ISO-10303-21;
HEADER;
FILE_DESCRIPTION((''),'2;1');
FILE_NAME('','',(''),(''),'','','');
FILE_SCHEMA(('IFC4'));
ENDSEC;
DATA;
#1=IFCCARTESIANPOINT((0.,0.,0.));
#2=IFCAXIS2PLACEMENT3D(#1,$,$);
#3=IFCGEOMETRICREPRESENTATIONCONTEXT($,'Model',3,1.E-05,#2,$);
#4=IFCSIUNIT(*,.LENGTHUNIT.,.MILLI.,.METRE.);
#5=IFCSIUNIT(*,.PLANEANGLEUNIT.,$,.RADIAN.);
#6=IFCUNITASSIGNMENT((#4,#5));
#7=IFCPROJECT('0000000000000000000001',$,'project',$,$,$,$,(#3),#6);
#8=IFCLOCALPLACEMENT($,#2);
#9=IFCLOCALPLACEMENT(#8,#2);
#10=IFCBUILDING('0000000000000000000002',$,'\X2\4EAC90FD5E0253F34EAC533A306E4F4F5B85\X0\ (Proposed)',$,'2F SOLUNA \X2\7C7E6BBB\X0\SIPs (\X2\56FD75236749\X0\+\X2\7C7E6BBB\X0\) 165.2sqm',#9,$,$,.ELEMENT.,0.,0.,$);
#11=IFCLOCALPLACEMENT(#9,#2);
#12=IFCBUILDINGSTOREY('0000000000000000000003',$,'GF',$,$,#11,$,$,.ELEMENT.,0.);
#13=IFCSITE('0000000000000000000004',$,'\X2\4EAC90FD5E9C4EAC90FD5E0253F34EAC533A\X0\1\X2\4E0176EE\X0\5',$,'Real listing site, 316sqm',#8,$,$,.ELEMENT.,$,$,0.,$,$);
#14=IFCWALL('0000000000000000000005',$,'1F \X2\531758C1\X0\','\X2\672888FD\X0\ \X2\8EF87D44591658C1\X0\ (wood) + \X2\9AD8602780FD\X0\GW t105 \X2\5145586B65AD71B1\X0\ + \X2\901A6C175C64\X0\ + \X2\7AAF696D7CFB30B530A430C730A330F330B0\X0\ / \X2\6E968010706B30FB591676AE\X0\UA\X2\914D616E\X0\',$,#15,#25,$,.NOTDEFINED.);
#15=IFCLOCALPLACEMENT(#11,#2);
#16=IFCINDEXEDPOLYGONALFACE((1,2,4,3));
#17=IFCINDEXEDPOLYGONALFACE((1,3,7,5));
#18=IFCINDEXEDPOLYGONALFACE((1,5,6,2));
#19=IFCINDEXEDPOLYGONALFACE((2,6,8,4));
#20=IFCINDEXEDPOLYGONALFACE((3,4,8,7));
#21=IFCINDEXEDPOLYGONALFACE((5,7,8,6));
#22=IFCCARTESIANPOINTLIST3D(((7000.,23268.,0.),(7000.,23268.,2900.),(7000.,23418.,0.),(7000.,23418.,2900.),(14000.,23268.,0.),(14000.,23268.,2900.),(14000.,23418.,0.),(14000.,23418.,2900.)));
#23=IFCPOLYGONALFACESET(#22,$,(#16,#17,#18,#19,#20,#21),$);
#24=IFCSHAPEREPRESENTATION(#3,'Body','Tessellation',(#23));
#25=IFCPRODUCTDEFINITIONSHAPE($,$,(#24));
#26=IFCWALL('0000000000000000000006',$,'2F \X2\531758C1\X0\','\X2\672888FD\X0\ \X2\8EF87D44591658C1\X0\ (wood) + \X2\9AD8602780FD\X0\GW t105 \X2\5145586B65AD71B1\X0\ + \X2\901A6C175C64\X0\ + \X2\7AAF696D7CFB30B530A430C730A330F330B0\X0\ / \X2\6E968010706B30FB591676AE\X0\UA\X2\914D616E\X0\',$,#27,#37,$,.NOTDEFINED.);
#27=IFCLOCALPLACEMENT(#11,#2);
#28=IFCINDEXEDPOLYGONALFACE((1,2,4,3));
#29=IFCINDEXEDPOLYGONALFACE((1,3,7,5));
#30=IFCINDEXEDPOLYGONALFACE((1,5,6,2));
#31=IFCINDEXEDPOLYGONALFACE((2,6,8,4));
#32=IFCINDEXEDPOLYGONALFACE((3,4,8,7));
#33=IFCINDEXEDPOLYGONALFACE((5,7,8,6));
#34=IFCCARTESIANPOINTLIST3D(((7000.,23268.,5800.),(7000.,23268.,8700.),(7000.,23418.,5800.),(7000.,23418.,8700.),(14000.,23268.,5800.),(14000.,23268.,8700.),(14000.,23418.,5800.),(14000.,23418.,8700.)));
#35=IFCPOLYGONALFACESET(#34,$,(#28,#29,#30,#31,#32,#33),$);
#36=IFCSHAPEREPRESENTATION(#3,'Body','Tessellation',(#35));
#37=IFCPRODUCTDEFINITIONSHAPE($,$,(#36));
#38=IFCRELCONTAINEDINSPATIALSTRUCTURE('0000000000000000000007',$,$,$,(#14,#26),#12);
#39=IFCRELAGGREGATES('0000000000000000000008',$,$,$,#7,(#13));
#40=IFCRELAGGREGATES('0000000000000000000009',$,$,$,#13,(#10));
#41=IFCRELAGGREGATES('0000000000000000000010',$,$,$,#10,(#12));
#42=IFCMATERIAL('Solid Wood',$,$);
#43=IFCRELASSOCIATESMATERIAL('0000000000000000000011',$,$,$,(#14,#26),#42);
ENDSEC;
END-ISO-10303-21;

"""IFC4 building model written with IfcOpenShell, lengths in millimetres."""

from ifc_helpers import new_model, si_unit, frame, frame_2d, origin, place, context, project, spatial, rectangle, extrude, material, element, save


model = new_model("IFC4")

# Units and contexts
model_context = context("Model", 3, precision=1e-05, world=origin())
ifc_project = project(units=[si_unit("LENGTHUNIT", "METRE", prefix="MILLI"), si_unit("PLANEANGLEUNIT", "RADIAN")], contexts=[model_context])

# Site, building, storey
site_placement = place(None, origin())
site = spatial("IfcSite", under=ifc_project, at=site_placement, Name="京都府京都市右京区1丁目5", ObjectType="Real listing site, 316sqm", CompositionType="ELEMENT", RefElevation=0.0)
building_placement = place(site_placement, origin())
building = spatial("IfcBuilding", under=site, at=building_placement, Name="京都市右京区の住宅 (Proposed)", ObjectType="2F SOLUNA 籾殻SIPs (国産杉+籾殻) 165.2sqm", CompositionType="ELEMENT", ElevationOfRefHeight=0.0, ElevationOfTerrain=0.0)
storey_placement = place(building_placement, origin())
storey = spatial("IfcBuildingStorey", under=building, at=storey_placement, Name="GF", CompositionType="ELEMENT", Elevation=0.0)

# Shared definitions
ifc_material_1 = material(Name="Solid Wood")

# Wall
wall_1_placement = place(storey_placement, frame((3500.0, 11634.0, 0.0)))
element("IfcWall", 1, at=wall_1_placement, inside=storey, material=ifc_material_1, Name="1F 北壁", Description="木製 軸組外壁 (wood) + 高性能GW t105 充填断熱 + 通気層 + 窯業系サイディング / 準耐火・外皮UA配慮", PredefinedType="NOTDEFINED", context=model_context, shape_type="SweptSolid", body=[
    extrude(rectangle(XDim=7000.0, YDim=150.0, at=frame_2d((3500.0, 75.0))), frame((3500.0, 11634.0, 0.0)), (0.0, 0.0, 1.0), 2900.0),
])

# Wall
wall_2_placement = place(storey_placement, frame((3500.0, 11634.0, 2900.0)))
element("IfcWall", 2, at=wall_2_placement, inside=storey, material=ifc_material_1, Name="2F 北壁", Description="木製 軸組外壁 (wood) + 高性能GW t105 充填断熱 + 通気層 + 窯業系サイディング / 準耐火・外皮UA配慮", PredefinedType="NOTDEFINED", context=model_context, shape_type="SweptSolid", body=[
    extrude(rectangle(XDim=7000.0, YDim=150.0, at=frame_2d((3500.0, 75.0))), frame((3500.0, 11634.0, 2900.0)), (0.0, 0.0, 1.0), 2900.0),
])

save(model, "model.ifc")
